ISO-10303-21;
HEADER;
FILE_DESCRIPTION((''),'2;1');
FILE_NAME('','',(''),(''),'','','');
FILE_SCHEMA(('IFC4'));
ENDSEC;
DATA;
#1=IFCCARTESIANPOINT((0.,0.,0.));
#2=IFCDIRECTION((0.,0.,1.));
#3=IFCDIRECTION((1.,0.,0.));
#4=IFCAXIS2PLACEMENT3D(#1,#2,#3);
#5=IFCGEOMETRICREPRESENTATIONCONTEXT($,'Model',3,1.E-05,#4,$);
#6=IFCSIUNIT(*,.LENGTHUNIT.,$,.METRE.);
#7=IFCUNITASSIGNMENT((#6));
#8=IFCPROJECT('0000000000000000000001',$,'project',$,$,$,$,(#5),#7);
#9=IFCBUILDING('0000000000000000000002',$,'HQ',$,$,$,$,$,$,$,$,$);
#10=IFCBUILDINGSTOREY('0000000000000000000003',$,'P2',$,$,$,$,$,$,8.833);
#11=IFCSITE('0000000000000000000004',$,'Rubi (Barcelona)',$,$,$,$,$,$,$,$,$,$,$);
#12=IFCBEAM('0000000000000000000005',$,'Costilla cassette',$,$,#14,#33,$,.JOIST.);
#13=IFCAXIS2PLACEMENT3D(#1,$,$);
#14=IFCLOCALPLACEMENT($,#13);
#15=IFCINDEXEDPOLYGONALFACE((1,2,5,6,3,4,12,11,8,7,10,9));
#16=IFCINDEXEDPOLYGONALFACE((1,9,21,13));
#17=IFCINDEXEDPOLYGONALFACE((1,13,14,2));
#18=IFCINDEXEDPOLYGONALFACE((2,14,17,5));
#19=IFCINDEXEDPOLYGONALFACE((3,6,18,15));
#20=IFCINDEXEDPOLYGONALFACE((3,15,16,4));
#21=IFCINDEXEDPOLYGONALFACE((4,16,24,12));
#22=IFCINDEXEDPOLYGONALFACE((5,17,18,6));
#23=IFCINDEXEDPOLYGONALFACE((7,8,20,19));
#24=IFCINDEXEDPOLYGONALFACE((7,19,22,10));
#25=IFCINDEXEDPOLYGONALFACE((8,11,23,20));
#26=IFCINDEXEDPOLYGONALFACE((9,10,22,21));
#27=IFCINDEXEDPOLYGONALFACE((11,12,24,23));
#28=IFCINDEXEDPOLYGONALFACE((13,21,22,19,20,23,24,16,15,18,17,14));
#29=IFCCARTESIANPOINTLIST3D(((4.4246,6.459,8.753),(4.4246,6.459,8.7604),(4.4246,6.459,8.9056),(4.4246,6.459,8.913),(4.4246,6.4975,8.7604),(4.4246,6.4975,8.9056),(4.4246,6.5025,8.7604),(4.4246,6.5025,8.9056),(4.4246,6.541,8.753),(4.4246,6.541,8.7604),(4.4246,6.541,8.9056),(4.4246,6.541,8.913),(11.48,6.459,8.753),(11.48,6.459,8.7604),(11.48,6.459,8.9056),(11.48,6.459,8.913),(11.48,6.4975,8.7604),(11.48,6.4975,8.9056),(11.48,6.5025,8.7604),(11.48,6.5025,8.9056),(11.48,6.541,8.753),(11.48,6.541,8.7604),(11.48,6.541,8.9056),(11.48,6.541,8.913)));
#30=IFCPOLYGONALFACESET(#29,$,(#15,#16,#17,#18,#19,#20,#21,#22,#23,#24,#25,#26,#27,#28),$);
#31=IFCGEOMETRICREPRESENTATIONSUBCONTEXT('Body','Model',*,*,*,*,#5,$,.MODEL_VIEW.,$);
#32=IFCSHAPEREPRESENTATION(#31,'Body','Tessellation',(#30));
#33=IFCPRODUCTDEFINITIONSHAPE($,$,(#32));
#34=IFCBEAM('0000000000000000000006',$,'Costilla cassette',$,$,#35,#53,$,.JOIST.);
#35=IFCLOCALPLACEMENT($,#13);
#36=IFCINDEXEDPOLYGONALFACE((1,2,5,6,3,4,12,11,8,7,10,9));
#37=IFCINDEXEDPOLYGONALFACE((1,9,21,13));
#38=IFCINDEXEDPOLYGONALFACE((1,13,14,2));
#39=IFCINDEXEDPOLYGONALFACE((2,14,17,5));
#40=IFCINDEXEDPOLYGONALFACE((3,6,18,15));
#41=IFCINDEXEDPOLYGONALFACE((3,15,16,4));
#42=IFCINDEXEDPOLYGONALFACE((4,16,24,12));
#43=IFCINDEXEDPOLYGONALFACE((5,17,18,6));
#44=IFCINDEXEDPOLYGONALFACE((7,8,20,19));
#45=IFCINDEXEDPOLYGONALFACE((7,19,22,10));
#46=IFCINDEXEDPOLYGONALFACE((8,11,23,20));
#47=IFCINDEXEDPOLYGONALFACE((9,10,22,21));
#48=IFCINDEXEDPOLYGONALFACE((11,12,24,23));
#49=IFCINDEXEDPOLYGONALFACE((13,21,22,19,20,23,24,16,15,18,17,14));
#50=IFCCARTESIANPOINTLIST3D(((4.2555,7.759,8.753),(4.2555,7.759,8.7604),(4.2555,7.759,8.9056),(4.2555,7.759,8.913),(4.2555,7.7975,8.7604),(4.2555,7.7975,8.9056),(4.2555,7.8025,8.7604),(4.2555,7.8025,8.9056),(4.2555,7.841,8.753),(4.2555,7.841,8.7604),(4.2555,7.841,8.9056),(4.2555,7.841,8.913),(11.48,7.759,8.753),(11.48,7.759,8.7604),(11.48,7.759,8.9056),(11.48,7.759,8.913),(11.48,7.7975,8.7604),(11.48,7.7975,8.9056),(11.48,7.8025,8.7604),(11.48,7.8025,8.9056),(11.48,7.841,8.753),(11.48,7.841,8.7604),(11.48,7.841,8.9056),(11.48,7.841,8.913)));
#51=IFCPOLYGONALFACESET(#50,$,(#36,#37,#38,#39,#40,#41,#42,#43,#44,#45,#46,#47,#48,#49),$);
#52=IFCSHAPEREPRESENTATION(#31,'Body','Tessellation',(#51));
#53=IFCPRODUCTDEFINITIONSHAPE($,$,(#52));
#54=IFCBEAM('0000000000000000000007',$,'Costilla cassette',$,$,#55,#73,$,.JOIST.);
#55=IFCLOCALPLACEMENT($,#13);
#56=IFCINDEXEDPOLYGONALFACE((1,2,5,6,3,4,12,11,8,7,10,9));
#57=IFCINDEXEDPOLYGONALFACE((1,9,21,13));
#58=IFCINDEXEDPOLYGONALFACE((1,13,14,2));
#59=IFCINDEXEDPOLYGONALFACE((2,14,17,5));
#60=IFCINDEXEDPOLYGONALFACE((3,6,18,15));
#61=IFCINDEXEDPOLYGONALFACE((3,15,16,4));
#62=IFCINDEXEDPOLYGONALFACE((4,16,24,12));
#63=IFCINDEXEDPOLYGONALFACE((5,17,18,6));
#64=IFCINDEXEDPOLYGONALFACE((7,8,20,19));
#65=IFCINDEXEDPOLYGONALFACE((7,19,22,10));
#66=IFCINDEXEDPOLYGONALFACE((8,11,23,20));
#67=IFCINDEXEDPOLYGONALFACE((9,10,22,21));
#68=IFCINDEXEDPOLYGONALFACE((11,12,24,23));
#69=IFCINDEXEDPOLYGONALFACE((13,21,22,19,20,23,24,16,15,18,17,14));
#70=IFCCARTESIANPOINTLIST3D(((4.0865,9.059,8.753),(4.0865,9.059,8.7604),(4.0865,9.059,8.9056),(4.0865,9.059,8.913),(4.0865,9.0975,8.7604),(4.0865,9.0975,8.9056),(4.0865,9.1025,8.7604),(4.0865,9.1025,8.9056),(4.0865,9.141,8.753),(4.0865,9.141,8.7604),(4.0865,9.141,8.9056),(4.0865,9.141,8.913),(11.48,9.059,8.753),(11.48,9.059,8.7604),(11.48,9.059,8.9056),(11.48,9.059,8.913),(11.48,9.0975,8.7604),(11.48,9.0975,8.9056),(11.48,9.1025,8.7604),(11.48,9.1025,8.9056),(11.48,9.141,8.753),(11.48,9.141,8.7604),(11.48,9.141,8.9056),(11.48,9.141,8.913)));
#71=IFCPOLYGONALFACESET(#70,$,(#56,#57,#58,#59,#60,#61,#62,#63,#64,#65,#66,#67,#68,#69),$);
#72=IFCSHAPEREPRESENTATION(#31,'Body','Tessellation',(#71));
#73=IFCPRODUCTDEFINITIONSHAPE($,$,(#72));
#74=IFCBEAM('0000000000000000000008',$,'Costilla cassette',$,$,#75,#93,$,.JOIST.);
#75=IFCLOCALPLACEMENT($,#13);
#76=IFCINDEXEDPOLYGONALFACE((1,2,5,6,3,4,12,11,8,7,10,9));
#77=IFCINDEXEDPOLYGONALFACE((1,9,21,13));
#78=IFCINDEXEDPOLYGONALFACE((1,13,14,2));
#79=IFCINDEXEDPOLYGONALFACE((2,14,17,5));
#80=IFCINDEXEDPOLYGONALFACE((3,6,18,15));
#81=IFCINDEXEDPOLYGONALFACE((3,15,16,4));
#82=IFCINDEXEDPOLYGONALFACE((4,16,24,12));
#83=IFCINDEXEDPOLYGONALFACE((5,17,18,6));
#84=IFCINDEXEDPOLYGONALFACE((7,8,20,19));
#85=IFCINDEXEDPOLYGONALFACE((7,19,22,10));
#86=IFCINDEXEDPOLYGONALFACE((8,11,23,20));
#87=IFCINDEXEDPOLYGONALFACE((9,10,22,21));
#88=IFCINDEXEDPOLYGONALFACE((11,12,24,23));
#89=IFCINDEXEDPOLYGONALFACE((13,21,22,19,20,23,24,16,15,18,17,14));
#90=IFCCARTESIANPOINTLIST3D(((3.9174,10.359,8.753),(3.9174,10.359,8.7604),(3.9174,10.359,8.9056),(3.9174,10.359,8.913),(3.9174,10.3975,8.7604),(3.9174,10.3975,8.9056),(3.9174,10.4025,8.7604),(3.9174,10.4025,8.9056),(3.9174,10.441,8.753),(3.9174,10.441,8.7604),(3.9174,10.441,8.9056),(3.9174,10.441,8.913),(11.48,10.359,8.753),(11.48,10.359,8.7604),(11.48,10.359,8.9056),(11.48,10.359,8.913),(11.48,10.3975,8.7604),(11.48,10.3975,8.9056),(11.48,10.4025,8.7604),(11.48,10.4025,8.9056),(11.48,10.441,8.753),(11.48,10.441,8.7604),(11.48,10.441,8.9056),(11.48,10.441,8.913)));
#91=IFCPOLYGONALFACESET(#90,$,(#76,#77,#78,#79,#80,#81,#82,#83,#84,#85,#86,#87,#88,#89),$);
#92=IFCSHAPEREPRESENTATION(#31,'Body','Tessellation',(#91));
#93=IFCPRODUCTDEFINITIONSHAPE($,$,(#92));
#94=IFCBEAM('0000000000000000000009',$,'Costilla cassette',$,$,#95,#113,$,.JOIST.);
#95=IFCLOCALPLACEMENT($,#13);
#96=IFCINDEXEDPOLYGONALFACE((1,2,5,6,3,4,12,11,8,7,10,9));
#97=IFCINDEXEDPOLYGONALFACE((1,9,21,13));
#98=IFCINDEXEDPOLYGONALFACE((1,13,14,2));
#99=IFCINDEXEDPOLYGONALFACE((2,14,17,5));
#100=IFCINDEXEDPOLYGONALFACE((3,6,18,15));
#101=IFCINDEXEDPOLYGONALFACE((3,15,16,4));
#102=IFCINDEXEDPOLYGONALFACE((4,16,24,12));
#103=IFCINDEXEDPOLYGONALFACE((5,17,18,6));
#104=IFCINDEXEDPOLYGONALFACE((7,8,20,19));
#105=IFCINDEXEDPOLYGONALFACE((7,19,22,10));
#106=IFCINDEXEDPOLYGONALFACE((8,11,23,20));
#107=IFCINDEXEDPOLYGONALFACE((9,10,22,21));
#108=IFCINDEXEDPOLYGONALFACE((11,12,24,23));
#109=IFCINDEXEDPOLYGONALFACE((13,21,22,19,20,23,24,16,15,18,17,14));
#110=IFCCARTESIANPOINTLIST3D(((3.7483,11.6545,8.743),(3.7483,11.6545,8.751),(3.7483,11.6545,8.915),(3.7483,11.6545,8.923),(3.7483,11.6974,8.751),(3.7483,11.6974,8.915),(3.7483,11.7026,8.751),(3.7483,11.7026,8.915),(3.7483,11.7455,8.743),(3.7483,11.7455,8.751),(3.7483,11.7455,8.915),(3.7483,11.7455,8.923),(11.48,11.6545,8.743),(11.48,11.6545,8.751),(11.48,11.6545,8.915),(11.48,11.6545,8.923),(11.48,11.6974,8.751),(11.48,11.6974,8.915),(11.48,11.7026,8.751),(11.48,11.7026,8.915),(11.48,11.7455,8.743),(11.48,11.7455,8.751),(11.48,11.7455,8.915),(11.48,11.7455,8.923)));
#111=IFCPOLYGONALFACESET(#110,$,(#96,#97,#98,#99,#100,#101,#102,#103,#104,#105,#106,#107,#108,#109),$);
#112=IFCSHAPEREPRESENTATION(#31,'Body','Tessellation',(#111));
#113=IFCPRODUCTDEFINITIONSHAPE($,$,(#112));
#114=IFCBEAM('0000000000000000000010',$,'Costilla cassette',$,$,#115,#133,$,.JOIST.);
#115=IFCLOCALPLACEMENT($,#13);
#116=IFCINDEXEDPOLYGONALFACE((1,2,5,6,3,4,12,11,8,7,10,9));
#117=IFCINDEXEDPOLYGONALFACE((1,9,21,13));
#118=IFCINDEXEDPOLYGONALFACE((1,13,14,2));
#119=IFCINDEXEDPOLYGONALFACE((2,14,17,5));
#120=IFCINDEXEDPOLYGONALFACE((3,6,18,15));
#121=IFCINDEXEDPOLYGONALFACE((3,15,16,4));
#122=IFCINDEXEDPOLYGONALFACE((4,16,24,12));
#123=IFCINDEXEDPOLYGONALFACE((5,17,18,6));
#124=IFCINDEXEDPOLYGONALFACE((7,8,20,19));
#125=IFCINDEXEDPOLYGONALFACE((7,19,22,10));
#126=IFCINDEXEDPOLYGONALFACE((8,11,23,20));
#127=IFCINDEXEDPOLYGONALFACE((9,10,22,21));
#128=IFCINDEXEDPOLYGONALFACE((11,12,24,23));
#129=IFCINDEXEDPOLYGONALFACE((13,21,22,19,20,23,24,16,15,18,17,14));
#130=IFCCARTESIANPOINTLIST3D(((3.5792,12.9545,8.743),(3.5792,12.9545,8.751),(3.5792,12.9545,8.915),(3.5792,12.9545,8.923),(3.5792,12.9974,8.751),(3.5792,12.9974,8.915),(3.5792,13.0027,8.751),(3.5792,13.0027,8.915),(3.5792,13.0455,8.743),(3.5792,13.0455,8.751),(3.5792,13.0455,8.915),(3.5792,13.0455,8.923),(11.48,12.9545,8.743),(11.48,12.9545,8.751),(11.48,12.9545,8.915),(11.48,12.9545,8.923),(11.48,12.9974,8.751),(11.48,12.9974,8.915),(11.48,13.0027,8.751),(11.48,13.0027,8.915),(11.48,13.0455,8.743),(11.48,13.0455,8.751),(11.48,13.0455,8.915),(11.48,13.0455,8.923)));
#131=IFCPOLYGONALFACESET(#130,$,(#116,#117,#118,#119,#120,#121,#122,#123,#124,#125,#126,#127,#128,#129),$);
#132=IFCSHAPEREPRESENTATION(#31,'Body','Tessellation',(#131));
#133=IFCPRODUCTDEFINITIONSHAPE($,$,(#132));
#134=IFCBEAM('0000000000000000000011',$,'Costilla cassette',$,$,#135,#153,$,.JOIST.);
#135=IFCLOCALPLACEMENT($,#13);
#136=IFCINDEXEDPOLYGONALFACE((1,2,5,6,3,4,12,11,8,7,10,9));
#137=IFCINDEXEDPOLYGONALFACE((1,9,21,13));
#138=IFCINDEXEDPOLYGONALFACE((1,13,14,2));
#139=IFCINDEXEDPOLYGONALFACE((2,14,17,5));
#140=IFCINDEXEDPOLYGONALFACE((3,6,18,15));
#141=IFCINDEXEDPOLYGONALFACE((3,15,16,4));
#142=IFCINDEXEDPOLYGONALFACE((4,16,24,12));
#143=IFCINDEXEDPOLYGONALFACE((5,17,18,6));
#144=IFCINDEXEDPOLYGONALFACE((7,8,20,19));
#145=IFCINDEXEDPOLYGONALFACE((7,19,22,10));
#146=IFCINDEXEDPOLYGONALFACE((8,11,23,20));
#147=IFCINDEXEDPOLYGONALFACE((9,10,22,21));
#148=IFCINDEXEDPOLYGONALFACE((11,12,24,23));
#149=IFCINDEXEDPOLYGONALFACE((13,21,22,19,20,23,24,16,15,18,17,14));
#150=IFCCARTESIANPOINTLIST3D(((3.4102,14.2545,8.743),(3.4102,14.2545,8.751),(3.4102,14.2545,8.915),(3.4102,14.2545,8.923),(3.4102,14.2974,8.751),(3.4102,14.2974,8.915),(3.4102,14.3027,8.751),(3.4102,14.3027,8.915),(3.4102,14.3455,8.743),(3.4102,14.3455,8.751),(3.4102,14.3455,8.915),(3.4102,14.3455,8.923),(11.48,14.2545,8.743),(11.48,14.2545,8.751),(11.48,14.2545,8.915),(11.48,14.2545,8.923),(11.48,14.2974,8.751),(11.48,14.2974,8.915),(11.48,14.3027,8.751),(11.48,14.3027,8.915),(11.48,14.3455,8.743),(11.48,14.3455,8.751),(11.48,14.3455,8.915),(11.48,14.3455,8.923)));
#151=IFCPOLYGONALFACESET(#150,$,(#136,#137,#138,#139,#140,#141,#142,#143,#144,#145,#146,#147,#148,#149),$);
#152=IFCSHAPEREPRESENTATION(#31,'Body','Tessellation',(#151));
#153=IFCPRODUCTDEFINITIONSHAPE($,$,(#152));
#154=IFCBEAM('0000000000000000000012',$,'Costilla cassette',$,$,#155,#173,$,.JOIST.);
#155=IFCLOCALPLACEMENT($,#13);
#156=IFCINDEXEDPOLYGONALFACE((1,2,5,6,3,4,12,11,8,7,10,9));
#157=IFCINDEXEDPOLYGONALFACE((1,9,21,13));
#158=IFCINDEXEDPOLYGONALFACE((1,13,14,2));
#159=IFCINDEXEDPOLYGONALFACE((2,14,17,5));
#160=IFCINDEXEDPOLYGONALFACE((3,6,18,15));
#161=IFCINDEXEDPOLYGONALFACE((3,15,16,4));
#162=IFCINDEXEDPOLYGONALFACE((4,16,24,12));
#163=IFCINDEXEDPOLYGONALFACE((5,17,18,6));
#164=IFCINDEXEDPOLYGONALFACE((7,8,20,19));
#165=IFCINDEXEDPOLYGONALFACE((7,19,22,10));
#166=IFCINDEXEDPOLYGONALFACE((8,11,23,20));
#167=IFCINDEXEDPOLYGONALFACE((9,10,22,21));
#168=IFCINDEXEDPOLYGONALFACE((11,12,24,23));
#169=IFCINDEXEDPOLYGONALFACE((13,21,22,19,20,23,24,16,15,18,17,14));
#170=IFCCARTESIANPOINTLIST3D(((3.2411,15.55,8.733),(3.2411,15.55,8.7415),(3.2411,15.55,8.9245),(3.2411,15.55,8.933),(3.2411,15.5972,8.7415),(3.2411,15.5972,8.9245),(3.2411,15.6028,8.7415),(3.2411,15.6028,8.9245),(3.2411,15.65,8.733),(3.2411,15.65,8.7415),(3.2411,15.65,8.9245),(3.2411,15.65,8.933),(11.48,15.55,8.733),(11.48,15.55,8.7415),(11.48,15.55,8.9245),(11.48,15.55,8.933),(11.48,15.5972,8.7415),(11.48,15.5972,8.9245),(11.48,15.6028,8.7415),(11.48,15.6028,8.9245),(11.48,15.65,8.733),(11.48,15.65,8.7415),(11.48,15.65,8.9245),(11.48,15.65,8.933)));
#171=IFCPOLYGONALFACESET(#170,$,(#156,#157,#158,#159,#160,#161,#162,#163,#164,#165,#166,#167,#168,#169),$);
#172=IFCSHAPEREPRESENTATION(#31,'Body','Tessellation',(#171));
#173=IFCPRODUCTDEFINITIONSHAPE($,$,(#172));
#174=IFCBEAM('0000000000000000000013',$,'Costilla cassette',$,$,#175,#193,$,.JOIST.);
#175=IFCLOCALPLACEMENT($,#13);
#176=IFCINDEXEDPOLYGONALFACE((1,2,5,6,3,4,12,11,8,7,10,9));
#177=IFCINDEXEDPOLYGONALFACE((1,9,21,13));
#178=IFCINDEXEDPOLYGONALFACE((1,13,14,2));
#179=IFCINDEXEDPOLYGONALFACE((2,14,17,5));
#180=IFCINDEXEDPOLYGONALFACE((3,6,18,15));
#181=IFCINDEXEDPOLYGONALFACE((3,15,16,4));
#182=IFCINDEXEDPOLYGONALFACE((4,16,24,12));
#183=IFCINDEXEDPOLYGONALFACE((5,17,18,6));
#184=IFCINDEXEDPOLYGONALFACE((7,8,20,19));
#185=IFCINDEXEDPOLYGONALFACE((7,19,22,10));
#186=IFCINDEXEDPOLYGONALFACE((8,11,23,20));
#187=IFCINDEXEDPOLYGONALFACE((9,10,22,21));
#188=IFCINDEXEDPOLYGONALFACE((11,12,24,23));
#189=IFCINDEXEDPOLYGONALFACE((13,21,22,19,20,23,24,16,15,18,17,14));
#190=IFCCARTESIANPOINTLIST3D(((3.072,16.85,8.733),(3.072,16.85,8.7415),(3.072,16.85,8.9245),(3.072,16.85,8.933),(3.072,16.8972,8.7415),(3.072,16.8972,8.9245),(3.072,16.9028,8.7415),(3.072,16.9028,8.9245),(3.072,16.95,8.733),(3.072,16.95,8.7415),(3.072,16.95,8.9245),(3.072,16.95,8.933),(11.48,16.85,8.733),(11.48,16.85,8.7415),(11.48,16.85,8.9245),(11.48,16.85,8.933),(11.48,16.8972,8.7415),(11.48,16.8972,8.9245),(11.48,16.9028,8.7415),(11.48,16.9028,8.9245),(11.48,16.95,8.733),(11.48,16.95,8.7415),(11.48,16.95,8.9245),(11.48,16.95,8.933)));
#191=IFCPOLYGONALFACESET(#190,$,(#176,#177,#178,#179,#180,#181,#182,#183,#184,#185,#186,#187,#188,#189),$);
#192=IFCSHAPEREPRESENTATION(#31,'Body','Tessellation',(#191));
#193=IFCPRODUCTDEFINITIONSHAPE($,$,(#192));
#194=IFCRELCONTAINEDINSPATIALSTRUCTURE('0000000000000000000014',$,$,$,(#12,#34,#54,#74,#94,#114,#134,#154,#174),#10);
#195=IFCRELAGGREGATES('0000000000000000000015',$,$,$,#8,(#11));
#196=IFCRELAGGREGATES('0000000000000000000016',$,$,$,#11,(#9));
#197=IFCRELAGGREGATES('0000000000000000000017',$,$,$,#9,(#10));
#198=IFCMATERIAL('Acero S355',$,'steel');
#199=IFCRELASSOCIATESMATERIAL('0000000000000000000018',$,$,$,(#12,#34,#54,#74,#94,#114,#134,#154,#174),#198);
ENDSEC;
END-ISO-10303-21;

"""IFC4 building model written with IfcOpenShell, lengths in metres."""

from ifc_helpers import new_model, si_unit, frame, origin_with_axes, place, context, subcontext, project, spatial, i_section, extrude, material, element, save


model = new_model("IFC4")

# Units and contexts
model_context = context("Model", 3, precision=1e-05, world=origin_with_axes())
body_context = subcontext(model_context, "Body", "Model", "MODEL_VIEW")
ifc_project = project(units=[si_unit("LENGTHUNIT", "METRE")], contexts=[model_context])

# Site, building, storey
site = spatial("IfcSite", under=ifc_project, Name="Rubi (Barcelona)")
building = spatial("IfcBuilding", under=site, Name="HQ")
storey = spatial("IfcBuildingStorey", under=building, Name="P2", Elevation=8.833)

# Beams
ifc_material_1 = material(Name="Acero S355", Category="steel")
beam_1_placement = place(None, origin_with_axes())
element("IfcBeam", 1, at=beam_1_placement, inside=storey, material=ifc_material_1, Name="Costilla cassette", PredefinedType="JOIST", context=body_context, shape_type="SweptSolid", body=[
    extrude(i_section(OverallWidth=0.082, OverallDepth=0.16, WebThickness=0.005, FlangeThickness=0.0074), frame((4.4246, 6.5, 8.833), z_axis=(1.0, 0.0, 0.0), x_axis=(0.0, 1.0, 0.0)), (0.0, 0.0, 1.0), 7.0554),
])
beam_2_placement = place(None, origin_with_axes())
element("IfcBeam", 2, at=beam_2_placement, inside=storey, material=ifc_material_1, Name="Costilla cassette", PredefinedType="JOIST", context=body_context, shape_type="SweptSolid", body=[
    extrude(i_section(OverallWidth=0.082, OverallDepth=0.16, WebThickness=0.005, FlangeThickness=0.0074), frame((4.2555, 7.8, 8.833), z_axis=(1.0, 0.0, 0.0), x_axis=(0.0, 1.0, 0.0)), (0.0, 0.0, 1.0), 7.2245),
])
beam_3_placement = place(None, origin_with_axes())
element("IfcBeam", 3, at=beam_3_placement, inside=storey, material=ifc_material_1, Name="Costilla cassette", PredefinedType="JOIST", context=body_context, shape_type="SweptSolid", body=[
    extrude(i_section(OverallWidth=0.082, OverallDepth=0.16, WebThickness=0.005, FlangeThickness=0.0074), frame((4.0865, 9.1, 8.833), z_axis=(1.0, 0.0, 0.0), x_axis=(0.0, 1.0, 0.0)), (0.0, 0.0, 1.0), 7.3935),
])
beam_4_placement = place(None, origin_with_axes())
element("IfcBeam", 4, at=beam_4_placement, inside=storey, material=ifc_material_1, Name="Costilla cassette", PredefinedType="JOIST", context=body_context, shape_type="SweptSolid", body=[
    extrude(i_section(OverallWidth=0.082, OverallDepth=0.16, WebThickness=0.005, FlangeThickness=0.0074), frame((3.9174, 10.4, 8.833), z_axis=(1.0, 0.0, 0.0), x_axis=(0.0, 1.0, 0.0)), (0.0, 0.0, 1.0), 7.5626),
])
beam_5_placement = place(None, origin_with_axes())
element("IfcBeam", 5, at=beam_5_placement, inside=storey, material=ifc_material_1, Name="Costilla cassette", PredefinedType="JOIST", context=body_context, shape_type="SweptSolid", body=[
    extrude(i_section(OverallWidth=0.091, OverallDepth=0.18, WebThickness=0.0053, FlangeThickness=0.008), frame((3.7483, 11.7, 8.833), z_axis=(1.0, 0.0, 0.0), x_axis=(0.0, 1.0, 0.0)), (0.0, 0.0, 1.0), 7.7317),
])
beam_6_placement = place(None, origin_with_axes())
element("IfcBeam", 6, at=beam_6_placement, inside=storey, material=ifc_material_1, Name="Costilla cassette", PredefinedType="JOIST", context=body_context, shape_type="SweptSolid", body=[
    extrude(i_section(OverallWidth=0.091, OverallDepth=0.18, WebThickness=0.0053, FlangeThickness=0.008), frame((3.5792, 13.0, 8.833), z_axis=(1.0, 0.0, 0.0), x_axis=(0.0, 1.0, 0.0)), (0.0, 0.0, 1.0), 7.9008),
])
beam_7_placement = place(None, origin_with_axes())
element("IfcBeam", 7, at=beam_7_placement, inside=storey, material=ifc_material_1, Name="Costilla cassette", PredefinedType="JOIST", context=body_context, shape_type="SweptSolid", body=[
    extrude(i_section(OverallWidth=0.091, OverallDepth=0.18, WebThickness=0.0053, FlangeThickness=0.008), frame((3.4102, 14.3, 8.833), z_axis=(1.0, 0.0, 0.0), x_axis=(0.0, 1.0, 0.0)), (0.0, 0.0, 1.0), 8.0698),
])
beam_8_placement = place(None, origin_with_axes())
element("IfcBeam", 8, at=beam_8_placement, inside=storey, material=ifc_material_1, Name="Costilla cassette", PredefinedType="JOIST", context=body_context, shape_type="SweptSolid", body=[
    extrude(i_section(OverallWidth=0.1, OverallDepth=0.2, WebThickness=0.0056, FlangeThickness=0.0085), frame((3.2411, 15.6, 8.833), z_axis=(1.0, 0.0, 0.0), x_axis=(0.0, 1.0, 0.0)), (0.0, 0.0, 1.0), 8.2389),
])
beam_9_placement = place(None, origin_with_axes())
element("IfcBeam", 9, at=beam_9_placement, inside=storey, material=ifc_material_1, Name="Costilla cassette", PredefinedType="JOIST", context=body_context, shape_type="SweptSolid", body=[
    extrude(i_section(OverallWidth=0.1, OverallDepth=0.2, WebThickness=0.0056, FlangeThickness=0.0085), frame((3.072, 16.9, 8.833), z_axis=(1.0, 0.0, 0.0), x_axis=(0.0, 1.0, 0.0)), (0.0, 0.0, 1.0), 8.408),
])

save(model, "model.ifc")
